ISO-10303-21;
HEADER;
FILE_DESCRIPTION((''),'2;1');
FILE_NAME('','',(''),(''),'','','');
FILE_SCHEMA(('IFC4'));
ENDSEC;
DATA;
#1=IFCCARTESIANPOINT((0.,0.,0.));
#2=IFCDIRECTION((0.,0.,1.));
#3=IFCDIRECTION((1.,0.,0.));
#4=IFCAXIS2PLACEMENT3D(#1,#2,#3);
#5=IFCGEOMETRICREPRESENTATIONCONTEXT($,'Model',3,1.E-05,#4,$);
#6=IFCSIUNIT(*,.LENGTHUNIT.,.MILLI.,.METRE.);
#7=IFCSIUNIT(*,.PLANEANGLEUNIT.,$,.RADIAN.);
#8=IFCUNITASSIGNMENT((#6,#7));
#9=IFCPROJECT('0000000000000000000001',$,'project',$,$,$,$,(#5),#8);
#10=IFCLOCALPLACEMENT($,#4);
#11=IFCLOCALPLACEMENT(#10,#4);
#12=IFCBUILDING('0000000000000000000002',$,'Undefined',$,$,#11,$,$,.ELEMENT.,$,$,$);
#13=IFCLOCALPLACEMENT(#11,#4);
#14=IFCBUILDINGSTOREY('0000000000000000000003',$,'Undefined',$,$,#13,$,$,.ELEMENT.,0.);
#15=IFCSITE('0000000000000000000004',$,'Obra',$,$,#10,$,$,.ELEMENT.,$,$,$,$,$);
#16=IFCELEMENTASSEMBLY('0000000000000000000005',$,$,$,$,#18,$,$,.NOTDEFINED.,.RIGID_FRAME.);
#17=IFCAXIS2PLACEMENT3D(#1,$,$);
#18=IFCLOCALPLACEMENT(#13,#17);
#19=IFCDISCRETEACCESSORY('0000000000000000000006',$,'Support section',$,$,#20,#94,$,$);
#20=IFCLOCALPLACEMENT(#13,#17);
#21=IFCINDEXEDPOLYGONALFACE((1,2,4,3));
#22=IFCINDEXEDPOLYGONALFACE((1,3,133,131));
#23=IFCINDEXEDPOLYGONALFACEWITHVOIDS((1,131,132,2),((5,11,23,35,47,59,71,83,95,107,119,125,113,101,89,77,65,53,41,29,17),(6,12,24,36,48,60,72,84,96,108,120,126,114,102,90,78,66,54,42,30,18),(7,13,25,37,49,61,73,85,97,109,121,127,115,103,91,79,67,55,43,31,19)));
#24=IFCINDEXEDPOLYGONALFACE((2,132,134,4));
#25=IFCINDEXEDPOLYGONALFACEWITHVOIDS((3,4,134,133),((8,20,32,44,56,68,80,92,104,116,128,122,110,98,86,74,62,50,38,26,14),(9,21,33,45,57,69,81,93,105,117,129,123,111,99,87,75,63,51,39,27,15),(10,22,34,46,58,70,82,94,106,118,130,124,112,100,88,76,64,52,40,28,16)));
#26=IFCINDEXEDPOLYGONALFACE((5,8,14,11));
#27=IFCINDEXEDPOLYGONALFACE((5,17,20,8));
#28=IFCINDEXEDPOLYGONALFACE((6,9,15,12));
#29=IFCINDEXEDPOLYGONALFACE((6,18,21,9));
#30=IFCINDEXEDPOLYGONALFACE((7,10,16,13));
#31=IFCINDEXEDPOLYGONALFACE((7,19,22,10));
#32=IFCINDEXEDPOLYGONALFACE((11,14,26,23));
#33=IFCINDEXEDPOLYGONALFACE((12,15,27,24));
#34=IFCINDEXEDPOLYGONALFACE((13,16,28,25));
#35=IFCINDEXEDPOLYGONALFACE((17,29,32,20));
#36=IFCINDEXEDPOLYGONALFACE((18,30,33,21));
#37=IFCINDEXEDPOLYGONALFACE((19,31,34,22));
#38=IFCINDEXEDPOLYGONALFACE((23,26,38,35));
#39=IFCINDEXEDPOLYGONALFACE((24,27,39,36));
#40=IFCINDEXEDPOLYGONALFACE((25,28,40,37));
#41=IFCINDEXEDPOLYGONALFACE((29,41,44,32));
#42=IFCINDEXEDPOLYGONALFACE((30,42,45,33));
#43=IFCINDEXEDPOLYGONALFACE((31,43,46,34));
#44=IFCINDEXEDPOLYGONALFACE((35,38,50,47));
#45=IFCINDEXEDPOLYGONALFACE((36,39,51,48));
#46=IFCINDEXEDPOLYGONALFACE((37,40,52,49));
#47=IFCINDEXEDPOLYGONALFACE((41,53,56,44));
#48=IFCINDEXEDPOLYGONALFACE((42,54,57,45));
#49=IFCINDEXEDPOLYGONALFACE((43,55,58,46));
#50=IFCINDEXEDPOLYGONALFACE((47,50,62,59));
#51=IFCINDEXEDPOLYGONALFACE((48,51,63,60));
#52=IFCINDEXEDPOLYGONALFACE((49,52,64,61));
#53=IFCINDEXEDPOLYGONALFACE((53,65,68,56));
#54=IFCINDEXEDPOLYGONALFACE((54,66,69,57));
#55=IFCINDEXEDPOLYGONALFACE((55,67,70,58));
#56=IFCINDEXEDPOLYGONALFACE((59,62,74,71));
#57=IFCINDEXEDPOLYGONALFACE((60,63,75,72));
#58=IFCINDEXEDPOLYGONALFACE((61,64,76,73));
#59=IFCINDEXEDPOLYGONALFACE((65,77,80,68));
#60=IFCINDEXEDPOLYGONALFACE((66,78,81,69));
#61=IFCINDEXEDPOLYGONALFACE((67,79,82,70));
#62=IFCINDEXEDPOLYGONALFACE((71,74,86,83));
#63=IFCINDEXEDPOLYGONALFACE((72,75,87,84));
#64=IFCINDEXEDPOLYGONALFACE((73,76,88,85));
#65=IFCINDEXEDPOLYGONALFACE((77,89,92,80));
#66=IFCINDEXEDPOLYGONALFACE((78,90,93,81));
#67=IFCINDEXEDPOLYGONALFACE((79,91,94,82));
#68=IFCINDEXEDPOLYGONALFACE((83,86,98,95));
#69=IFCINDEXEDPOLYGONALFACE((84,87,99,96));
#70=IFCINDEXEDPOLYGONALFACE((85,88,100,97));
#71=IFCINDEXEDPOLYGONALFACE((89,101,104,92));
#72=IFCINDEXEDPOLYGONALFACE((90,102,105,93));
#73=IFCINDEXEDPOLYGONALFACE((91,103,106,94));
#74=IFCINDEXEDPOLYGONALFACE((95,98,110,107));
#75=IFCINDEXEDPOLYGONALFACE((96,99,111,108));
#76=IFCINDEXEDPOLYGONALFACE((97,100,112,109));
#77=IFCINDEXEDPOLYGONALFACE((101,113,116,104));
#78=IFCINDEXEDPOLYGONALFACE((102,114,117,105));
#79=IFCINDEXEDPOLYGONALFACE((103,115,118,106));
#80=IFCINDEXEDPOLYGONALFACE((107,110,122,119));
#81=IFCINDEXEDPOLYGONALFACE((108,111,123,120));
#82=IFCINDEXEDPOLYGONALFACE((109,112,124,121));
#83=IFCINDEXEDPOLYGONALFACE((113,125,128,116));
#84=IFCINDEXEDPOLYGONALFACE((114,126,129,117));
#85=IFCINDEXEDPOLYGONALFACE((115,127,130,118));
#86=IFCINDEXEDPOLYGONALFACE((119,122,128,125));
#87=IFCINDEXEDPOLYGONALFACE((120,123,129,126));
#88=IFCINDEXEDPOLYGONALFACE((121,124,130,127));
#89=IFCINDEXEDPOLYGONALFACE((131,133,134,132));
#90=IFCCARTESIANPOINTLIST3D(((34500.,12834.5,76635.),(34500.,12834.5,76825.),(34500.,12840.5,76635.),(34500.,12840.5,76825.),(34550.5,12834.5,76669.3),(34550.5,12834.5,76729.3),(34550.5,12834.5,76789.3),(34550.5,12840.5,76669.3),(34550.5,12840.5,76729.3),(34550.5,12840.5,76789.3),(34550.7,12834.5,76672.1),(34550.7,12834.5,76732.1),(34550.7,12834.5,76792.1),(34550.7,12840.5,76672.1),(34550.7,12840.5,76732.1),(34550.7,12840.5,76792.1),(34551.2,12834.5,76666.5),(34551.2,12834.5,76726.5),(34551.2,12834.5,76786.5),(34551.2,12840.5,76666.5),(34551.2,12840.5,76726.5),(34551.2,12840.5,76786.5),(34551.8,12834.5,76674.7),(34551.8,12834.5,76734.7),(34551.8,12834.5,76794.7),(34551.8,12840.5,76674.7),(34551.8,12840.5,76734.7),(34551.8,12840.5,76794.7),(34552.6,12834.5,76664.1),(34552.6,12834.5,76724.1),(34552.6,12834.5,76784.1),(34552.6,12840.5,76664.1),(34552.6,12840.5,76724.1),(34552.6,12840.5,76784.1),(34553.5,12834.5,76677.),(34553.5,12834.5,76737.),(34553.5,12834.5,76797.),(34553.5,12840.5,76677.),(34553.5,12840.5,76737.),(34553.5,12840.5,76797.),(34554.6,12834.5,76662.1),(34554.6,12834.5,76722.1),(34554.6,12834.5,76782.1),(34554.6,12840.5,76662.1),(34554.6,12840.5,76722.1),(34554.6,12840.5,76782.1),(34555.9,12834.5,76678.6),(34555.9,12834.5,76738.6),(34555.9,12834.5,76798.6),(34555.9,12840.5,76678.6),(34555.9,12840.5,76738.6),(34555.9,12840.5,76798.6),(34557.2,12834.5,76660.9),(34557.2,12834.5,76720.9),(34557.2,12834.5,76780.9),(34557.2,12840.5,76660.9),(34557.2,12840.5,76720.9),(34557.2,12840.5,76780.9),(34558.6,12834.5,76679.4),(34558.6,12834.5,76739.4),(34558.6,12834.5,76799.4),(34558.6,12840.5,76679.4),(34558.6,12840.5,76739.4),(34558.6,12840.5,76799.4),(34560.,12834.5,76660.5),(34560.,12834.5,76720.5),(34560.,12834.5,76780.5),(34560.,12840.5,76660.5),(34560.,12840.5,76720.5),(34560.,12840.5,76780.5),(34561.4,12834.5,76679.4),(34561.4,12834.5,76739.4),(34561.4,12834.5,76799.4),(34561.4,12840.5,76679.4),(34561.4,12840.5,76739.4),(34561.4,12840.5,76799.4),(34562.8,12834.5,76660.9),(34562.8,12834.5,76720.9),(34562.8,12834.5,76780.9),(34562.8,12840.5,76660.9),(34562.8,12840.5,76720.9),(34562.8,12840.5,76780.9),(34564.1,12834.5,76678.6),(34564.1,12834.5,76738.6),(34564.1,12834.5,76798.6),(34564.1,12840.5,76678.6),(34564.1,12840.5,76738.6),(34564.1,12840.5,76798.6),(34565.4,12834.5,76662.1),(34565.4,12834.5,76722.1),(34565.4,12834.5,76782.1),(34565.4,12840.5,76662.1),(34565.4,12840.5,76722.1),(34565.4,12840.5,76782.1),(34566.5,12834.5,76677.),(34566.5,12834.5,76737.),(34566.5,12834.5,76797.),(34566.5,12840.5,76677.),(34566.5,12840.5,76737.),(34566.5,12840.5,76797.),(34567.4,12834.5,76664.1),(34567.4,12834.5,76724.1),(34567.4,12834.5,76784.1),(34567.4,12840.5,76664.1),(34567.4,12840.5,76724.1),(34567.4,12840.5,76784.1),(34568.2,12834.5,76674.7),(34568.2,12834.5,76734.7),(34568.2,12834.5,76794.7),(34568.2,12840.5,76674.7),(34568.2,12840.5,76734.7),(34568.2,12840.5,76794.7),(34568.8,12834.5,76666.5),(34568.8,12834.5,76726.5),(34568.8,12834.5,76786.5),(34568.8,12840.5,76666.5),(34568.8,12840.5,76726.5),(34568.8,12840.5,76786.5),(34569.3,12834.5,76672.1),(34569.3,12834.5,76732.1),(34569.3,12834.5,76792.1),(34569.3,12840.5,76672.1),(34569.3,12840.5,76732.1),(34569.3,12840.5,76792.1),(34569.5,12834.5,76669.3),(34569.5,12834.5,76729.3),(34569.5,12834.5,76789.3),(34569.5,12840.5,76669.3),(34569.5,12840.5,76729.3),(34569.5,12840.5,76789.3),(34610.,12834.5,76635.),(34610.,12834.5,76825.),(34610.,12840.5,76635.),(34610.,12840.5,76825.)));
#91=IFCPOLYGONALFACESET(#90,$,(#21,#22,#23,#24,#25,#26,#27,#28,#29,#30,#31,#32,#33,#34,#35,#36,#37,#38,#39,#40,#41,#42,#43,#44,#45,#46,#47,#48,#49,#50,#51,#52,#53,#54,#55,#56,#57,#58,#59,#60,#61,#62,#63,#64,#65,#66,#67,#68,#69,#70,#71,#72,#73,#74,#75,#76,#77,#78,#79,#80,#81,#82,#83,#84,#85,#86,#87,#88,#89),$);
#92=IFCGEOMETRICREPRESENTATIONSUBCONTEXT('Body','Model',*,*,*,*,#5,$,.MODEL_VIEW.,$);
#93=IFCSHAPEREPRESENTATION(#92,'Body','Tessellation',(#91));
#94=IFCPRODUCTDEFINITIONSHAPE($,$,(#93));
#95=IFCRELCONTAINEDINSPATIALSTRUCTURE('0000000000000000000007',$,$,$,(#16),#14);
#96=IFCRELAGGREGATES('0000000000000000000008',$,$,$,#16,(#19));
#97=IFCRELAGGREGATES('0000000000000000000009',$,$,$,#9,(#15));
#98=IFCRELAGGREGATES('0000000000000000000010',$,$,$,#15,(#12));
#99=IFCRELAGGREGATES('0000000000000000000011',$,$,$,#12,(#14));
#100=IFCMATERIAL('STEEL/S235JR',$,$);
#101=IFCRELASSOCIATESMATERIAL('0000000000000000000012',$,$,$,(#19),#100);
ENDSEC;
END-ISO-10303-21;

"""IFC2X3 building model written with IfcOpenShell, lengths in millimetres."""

from ifc_helpers import new_model, si_unit, frame, origin_with_axes, origin_2d_with_axis, place, context, subcontext, project, spatial, rectangle, circle, extrude, source, transform, mapped, material, element, aggregate, save


model = new_model("IFC2X3")

# Units and contexts
model_context = context("Model", 3, precision=1e-05, world=origin_with_axes())
body_context = subcontext(model_context, "Body", "Model", "MODEL_VIEW")
ifc_project = project(units=[si_unit("LENGTHUNIT", "METRE", prefix="MILLI"), si_unit("PLANEANGLEUNIT", "RADIAN")], contexts=[model_context])

# Site, building, storey
site_placement = place(None, origin_with_axes())
site = spatial("IfcSite", under=ifc_project, at=site_placement, Name="Obra", CompositionType="ELEMENT")
building_placement = place(site_placement, origin_with_axes())
building = spatial("IfcBuilding", under=site, at=building_placement, Name="Undefined", CompositionType="ELEMENT")
storey_placement = place(building_placement, origin_with_axes())
storey = spatial("IfcBuildingStorey", under=building, at=storey_placement, Name="Undefined", CompositionType="ELEMENT", Elevation=0.0)

# Element assembly
ifc_material = material(Name="STEEL/S235JR")
assembly_1_placement = place(storey_placement, origin_with_axes())
assembly_1 = element("IfcElementAssembly", 1, at=assembly_1_placement, inside=storey, AssemblyPlace="NOTDEFINED", PredefinedType="RIGID_FRAME")

# Shared definitions
shared_shape_1 = source(origin_with_axes(), body_context, "Body", "SweptSolid", [
    extrude(circle(Radius=9.5, at=origin_2d_with_axis()), frame((0.0, -9.2, 0.0), z_axis=(0.0, 1.0, 0.0), x_axis=(1.0, 0.0, 0.0)), (0.0, 0.0, 1.0), 6.2),
])

# Discrete accessory, opening
discrete_accessory_1_placement = place(assembly_1_placement, frame((34555.0, 12837.5, 76635.0), z_axis=(0.0, 0.0, 1.0), x_axis=(-1.0, 0.0, 0.0)))
discrete_accessory_1 = element("IfcDiscreteAccessory", 2, at=discrete_accessory_1_placement, material=ifc_material, Name="Support section", context=body_context, shape_type="SweptSolid", body=[
    extrude(rectangle(XDim=6.0, YDim=110.0, at=origin_2d_with_axis()), frame((0.0, 0.0, 190.0), z_axis=(0.0, 0.0, -1.0), x_axis=(0.0, 1.0, 0.0)), (0.0, 0.0, 1.0), 190.0),
])
opening_1_placement = place(assembly_1_placement, frame((34510.0, 12843.6, 76850.0), z_axis=(1.0, 0.0, 0.0), x_axis=(0.0, 0.0, -1.0)))
element("IfcOpeningElement", 3, at=opening_1_placement, cuts=discrete_accessory_1, ObjectType="Opening", context=body_context, shape_type="MappedRepresentation", body=[
    mapped(shared_shape_1, transform((60.0, 0.0, 50.0))),
    mapped(shared_shape_1, transform((120.0, 0.0, 50.0))),
    mapped(shared_shape_1, transform((180.0, 0.0, 50.0))),
])
aggregate(assembly_1, [discrete_accessory_1])

save(model, "model.ifc")
